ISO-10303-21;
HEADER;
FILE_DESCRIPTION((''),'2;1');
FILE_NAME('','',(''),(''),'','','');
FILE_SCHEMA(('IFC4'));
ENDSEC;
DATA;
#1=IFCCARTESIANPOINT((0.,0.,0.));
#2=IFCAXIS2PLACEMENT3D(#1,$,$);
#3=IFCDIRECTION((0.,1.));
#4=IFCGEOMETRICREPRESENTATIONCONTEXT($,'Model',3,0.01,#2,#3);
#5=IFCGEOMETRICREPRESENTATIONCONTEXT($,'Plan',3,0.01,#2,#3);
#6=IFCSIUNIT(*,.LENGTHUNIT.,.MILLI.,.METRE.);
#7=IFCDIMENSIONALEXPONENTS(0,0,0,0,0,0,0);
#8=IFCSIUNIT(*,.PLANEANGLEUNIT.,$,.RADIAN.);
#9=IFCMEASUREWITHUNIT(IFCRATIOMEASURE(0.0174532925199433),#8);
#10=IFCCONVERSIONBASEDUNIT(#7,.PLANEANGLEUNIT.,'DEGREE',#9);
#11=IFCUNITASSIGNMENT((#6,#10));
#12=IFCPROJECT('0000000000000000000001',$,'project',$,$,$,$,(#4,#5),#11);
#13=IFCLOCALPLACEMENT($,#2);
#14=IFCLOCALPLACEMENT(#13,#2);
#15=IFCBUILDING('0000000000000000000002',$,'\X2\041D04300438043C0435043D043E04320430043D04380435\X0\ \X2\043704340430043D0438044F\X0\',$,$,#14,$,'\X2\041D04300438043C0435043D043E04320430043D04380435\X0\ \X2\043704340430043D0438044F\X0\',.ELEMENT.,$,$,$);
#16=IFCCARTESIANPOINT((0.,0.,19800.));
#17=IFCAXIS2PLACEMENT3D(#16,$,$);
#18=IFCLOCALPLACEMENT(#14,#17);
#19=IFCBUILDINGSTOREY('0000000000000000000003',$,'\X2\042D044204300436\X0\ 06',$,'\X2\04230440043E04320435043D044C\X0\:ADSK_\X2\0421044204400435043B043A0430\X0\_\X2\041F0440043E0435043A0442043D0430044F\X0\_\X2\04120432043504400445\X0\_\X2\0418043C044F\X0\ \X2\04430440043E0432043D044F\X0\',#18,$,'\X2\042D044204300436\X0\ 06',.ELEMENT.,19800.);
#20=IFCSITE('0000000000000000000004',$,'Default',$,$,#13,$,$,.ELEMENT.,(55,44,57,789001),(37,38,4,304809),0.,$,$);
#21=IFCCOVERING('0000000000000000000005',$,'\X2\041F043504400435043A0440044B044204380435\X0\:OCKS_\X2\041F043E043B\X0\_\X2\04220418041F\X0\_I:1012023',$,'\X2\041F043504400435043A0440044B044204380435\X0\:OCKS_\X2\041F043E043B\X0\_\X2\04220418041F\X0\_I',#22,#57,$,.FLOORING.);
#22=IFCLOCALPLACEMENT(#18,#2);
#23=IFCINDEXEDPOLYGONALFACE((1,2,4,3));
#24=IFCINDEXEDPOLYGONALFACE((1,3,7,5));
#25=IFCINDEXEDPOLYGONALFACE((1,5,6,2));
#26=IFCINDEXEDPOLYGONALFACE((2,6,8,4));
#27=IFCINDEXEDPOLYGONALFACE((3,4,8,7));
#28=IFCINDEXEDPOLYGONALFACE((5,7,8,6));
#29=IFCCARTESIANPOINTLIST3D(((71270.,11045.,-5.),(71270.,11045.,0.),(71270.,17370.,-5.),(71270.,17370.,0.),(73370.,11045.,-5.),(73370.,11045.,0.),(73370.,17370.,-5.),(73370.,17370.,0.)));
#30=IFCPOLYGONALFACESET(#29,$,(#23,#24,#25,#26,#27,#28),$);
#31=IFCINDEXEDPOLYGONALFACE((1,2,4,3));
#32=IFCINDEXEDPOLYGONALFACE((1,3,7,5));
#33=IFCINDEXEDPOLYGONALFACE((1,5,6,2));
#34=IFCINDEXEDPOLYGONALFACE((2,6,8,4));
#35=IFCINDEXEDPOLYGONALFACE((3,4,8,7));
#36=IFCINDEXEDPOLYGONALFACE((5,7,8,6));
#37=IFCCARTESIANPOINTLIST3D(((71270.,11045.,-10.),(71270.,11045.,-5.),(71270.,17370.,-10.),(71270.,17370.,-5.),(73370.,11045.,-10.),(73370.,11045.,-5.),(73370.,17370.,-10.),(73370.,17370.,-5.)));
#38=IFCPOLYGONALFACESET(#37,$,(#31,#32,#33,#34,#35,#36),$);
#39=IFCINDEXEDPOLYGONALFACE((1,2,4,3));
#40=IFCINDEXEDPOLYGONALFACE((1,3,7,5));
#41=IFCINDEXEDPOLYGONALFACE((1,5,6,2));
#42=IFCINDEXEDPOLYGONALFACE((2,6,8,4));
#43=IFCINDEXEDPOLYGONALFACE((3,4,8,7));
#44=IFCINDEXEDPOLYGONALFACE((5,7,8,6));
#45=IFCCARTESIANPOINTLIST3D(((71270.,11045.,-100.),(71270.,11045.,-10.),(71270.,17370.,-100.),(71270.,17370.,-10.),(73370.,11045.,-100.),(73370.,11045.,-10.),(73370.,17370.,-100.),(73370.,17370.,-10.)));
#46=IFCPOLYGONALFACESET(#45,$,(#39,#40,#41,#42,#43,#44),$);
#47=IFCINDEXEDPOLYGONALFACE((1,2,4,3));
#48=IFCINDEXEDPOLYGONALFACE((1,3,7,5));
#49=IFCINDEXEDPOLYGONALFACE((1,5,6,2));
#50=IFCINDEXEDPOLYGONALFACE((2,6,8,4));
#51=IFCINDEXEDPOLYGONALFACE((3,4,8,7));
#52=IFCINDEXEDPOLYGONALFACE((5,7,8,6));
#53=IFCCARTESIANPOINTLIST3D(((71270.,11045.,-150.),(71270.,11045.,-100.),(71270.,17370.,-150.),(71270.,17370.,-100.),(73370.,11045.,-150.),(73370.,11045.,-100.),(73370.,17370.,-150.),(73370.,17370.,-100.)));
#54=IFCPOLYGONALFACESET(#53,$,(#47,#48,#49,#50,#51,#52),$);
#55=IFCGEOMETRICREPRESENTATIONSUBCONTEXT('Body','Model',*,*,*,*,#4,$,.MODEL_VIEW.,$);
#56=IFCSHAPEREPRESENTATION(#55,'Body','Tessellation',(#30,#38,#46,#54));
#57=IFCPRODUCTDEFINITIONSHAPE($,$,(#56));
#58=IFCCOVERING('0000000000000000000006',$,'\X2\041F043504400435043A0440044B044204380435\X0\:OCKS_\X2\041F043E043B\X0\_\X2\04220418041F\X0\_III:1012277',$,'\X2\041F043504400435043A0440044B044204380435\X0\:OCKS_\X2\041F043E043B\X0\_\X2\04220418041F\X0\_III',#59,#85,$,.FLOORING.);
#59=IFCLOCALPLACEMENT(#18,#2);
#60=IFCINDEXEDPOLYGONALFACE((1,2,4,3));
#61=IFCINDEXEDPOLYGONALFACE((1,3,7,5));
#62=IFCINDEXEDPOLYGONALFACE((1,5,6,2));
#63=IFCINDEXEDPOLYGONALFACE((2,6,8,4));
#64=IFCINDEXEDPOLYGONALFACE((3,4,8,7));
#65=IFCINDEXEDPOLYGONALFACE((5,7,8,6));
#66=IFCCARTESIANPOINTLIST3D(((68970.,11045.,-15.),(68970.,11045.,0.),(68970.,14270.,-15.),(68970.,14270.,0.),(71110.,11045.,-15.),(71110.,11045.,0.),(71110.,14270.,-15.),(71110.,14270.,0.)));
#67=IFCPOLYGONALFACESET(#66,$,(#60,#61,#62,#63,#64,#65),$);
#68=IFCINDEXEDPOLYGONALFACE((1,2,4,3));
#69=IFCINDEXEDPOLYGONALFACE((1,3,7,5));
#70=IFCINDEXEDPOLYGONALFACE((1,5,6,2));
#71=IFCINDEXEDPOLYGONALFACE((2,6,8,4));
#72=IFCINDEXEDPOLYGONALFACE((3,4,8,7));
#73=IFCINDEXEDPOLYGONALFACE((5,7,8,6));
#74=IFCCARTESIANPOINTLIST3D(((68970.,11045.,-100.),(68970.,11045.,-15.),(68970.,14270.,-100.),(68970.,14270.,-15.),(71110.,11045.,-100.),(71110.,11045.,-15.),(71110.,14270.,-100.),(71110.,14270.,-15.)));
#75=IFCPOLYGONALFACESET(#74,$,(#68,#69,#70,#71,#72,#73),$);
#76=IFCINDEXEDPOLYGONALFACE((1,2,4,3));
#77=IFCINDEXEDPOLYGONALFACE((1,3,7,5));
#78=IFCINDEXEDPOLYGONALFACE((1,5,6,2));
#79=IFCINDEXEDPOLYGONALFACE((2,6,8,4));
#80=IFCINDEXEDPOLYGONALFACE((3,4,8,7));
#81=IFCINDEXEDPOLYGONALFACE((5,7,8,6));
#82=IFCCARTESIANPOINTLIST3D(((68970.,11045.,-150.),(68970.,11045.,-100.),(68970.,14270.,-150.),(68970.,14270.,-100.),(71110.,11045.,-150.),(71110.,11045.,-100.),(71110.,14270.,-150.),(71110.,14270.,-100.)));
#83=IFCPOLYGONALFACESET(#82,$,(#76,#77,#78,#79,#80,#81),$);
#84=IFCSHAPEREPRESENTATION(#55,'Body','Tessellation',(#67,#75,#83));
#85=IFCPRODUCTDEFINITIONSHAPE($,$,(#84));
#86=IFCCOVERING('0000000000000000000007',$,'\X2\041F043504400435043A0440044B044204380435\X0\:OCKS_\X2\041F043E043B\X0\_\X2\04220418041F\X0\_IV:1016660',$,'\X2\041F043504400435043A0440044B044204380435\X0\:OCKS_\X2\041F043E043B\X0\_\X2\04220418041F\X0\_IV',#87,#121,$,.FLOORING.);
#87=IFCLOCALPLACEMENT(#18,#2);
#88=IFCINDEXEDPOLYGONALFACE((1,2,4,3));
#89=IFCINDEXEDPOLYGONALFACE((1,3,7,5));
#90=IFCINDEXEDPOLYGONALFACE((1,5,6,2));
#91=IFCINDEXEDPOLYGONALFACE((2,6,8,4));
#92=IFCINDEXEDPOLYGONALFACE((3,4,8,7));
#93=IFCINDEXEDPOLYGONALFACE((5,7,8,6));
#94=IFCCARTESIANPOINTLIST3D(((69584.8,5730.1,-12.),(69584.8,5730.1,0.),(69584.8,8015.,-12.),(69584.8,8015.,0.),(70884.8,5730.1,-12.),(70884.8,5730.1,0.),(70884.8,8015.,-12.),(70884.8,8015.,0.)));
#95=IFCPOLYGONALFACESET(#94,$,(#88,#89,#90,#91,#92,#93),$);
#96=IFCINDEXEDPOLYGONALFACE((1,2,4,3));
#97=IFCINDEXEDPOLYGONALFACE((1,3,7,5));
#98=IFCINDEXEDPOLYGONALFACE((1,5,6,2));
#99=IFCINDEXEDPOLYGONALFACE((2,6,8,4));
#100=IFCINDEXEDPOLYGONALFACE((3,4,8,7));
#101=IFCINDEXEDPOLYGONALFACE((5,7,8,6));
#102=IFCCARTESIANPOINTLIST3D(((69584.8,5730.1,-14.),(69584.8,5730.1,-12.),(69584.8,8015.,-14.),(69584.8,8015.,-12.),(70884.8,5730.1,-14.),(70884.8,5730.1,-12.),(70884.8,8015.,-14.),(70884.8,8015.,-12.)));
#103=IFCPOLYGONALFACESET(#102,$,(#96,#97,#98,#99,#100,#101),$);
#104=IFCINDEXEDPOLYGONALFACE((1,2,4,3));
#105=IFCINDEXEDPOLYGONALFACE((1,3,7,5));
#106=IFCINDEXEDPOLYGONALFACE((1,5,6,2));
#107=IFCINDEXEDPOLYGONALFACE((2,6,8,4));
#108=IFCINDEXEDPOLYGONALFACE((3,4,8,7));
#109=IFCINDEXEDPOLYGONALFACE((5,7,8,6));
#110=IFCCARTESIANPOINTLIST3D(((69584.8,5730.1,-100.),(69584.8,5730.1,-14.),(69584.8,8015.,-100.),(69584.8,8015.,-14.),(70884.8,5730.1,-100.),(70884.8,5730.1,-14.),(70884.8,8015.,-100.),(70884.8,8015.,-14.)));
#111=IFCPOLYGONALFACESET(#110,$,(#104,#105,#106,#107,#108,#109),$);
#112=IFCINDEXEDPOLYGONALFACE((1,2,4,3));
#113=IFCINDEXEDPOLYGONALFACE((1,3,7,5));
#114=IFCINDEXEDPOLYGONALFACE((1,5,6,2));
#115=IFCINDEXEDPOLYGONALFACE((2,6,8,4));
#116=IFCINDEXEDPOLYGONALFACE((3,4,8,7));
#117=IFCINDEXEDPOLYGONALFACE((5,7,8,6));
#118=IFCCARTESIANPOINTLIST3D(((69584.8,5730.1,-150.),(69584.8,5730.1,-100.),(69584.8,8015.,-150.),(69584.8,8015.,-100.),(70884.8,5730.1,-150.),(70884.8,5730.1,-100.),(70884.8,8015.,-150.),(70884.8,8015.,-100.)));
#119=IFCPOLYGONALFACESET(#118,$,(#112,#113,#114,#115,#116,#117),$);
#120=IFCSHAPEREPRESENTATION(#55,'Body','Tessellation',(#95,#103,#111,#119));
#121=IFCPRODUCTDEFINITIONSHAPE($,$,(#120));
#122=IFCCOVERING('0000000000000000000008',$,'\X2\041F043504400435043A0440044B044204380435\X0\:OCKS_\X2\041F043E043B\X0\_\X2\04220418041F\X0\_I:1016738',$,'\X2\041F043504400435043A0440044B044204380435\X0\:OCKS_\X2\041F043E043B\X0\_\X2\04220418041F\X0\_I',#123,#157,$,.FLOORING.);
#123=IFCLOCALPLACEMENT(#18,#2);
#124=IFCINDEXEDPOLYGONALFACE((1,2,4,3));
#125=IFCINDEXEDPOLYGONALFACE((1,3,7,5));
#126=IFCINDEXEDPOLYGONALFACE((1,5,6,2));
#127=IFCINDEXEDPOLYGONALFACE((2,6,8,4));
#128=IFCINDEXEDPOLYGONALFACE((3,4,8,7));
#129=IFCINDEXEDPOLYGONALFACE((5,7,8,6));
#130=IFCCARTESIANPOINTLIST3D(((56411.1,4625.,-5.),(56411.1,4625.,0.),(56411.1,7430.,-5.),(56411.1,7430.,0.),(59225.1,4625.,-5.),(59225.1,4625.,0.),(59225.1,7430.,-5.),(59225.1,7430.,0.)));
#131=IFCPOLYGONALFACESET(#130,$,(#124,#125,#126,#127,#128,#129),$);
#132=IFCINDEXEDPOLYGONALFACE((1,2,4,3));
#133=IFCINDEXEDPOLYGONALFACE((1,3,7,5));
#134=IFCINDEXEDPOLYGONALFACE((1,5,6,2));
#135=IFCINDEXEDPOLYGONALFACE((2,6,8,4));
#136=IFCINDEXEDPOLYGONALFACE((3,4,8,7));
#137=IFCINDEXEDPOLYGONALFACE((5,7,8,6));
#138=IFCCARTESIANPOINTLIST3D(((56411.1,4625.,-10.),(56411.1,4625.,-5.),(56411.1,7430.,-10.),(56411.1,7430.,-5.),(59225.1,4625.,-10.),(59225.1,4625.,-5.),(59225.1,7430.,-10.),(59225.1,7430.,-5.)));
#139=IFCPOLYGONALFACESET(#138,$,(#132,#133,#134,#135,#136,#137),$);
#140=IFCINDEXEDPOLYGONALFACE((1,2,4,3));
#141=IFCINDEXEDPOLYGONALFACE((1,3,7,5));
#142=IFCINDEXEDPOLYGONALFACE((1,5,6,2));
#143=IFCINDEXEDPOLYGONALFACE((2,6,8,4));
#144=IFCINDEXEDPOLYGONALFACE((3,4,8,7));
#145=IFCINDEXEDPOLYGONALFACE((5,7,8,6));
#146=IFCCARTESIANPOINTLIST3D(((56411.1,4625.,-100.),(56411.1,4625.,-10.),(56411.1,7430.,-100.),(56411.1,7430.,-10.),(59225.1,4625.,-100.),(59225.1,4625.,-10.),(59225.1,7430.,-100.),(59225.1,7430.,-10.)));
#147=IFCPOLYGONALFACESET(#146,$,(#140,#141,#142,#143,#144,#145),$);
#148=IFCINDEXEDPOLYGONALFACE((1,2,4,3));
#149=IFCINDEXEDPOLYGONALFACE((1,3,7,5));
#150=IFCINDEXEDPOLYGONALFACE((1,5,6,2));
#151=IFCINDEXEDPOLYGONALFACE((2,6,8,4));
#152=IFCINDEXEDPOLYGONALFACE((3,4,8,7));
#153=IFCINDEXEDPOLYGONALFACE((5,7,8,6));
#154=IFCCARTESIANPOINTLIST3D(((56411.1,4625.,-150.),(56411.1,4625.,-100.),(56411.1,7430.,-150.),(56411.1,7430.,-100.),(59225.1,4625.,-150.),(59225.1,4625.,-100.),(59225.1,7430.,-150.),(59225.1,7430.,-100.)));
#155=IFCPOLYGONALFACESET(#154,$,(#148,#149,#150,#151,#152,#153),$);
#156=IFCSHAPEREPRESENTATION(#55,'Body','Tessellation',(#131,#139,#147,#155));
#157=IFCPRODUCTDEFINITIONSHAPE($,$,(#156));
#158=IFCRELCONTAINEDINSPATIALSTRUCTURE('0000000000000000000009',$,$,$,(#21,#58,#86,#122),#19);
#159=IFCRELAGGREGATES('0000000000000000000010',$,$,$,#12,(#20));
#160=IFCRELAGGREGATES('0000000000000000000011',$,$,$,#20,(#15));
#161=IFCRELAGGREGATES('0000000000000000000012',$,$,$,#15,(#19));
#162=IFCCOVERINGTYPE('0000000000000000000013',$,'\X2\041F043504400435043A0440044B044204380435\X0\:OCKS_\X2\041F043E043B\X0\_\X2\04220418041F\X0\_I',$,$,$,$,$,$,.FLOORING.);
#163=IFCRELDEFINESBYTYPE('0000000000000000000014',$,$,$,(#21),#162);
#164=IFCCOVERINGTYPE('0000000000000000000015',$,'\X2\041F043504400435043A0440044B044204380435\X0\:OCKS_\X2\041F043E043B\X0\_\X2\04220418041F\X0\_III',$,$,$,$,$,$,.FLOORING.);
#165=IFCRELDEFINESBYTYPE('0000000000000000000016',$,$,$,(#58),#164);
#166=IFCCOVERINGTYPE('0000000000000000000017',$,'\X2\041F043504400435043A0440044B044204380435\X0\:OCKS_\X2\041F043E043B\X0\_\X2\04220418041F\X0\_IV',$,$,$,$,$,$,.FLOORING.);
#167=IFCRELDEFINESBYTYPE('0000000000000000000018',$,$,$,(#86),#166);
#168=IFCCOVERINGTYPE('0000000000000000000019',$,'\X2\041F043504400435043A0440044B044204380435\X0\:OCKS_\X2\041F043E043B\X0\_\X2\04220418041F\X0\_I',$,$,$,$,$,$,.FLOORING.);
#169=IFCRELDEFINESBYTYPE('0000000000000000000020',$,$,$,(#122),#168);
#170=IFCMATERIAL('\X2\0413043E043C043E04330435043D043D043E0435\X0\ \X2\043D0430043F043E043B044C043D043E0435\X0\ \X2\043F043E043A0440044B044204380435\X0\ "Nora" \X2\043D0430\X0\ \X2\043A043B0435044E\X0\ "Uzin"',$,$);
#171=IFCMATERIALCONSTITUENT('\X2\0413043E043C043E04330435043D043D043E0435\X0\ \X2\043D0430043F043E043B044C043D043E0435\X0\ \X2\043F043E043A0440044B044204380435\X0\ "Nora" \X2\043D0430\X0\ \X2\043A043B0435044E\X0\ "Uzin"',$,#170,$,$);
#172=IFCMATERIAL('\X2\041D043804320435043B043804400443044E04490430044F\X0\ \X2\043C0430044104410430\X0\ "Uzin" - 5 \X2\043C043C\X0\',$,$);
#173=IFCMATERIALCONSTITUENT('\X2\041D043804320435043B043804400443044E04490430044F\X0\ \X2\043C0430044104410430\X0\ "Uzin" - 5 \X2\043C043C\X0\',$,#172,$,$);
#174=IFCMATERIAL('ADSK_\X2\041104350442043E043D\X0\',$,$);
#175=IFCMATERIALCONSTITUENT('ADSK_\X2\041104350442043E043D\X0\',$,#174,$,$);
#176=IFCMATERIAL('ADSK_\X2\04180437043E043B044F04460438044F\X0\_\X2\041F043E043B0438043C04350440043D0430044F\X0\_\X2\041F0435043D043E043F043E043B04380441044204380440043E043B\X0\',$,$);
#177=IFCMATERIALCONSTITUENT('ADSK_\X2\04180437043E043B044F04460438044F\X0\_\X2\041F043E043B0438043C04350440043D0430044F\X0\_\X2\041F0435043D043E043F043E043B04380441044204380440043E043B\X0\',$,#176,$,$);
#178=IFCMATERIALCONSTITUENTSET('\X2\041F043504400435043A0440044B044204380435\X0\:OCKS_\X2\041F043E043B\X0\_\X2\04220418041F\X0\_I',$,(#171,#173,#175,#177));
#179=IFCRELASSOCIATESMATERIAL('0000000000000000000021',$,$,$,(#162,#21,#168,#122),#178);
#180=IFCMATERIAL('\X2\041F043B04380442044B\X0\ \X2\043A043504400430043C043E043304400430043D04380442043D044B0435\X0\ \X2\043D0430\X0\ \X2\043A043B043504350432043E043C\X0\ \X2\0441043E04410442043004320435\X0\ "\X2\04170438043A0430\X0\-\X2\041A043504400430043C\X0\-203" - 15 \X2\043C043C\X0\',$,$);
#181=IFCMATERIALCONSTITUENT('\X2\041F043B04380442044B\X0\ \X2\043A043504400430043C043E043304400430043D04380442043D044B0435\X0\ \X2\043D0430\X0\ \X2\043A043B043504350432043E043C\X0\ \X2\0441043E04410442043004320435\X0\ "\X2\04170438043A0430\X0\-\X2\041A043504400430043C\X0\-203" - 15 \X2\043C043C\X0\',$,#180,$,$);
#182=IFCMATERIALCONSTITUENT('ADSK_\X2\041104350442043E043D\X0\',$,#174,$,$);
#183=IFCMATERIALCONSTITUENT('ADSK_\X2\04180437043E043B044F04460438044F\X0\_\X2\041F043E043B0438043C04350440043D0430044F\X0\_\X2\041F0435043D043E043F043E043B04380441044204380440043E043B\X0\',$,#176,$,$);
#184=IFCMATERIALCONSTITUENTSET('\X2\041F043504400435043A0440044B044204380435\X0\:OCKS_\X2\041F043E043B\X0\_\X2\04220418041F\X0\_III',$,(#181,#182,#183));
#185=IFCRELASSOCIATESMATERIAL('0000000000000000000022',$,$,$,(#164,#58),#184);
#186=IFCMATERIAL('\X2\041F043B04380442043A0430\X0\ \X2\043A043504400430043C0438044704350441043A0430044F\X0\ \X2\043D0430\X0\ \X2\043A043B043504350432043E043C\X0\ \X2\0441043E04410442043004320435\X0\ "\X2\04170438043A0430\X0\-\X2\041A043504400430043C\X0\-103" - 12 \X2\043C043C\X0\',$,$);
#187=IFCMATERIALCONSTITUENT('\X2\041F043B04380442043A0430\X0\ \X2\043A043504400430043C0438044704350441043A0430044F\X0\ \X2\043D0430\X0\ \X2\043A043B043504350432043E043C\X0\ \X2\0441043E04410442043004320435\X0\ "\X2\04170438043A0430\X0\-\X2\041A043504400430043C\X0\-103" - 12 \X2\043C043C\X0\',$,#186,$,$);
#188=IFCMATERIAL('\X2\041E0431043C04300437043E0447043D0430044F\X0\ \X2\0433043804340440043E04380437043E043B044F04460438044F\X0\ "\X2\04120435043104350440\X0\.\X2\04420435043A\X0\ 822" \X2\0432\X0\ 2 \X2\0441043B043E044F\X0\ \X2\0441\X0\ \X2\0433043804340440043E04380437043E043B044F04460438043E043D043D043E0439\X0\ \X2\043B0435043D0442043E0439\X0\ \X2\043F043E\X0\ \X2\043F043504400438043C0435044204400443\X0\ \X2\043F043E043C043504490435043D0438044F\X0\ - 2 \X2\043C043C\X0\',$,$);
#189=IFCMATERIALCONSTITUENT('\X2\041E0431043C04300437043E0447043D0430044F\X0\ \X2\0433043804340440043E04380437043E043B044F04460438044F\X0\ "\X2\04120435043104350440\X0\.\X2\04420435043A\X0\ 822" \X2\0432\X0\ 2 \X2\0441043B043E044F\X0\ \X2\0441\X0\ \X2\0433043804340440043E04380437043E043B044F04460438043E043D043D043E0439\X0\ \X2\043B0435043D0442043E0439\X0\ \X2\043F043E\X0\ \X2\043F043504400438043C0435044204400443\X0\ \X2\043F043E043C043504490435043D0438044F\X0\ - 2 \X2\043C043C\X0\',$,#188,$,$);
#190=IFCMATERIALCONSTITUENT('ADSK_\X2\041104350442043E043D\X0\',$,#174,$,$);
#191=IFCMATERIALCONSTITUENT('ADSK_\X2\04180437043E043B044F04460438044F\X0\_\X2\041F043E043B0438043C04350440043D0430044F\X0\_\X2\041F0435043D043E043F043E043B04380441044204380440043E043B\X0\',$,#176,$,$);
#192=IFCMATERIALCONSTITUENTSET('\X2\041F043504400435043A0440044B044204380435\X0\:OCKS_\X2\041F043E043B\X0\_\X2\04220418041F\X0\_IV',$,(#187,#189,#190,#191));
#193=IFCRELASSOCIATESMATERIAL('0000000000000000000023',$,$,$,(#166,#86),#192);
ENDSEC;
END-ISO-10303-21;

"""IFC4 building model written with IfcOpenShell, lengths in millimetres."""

from ifc_helpers import new_model, entity, si_unit, converted_unit, direction, frame, origin, place, context, subcontext, project, spatial, indexed_curve, outline, extrude, material, constituent, constituent_set, type_object, element, save


model = new_model("IFC4")

# Units and contexts
model_context = context("Model", 3, precision=0.01, world=origin(), true_north=direction((0.0, 1.0)))
plan_context = context("Plan", 3, precision=0.01, world=origin(), true_north=direction((0.0, 1.0)))
body_context = subcontext(model_context, "Body", "Model", "MODEL_VIEW")
ifc_project = project(units=[si_unit("LENGTHUNIT", "METRE", prefix="MILLI"), converted_unit("PLANEANGLEUNIT", "DEGREE", entity("IfcRatioMeasure", 0.0174532925199433), si_unit("PLANEANGLEUNIT", "RADIAN"), dimensions=[0, 0, 0, 0, 0, 0, 0])], contexts=[model_context, plan_context])

# Site, building, storey
site_placement = place(None, frame((0.0, 0.0, 0.0)))
site = spatial("IfcSite", under=ifc_project, at=site_placement, Name="Default", CompositionType="ELEMENT", RefLatitude=(55, 44, 57, 789001), RefLongitude=(37, 38, 4, 304809), RefElevation=0.0)
building_placement = place(site_placement, origin())
building = spatial("IfcBuilding", under=site, at=building_placement, Name="Наименование здания", LongName="Наименование здания", CompositionType="ELEMENT")
storey_placement = place(building_placement, frame((0.0, 0.0, 19800.0)))
storey = spatial("IfcBuildingStorey", under=building, at=storey_placement, Name="Этаж 06", ObjectType="Уровень:ADSK_Стрелка_Проектная_Вверх_Имя уровня", LongName="Этаж 06", CompositionType="ELEMENT", Elevation=19800.0)

# Coverings
ifc_material_1 = material(Name="Плиты керамогранитные на клеевом составе \"Зика-Керам-203\" - 15 мм")
ifc_material_2 = material(Name="Обмазочная гидроизоляция \"Вебер.тек 822\" в 2 слоя с гидроизоляционной лентой по периметру помещения - 2 мм")
ifc_material_3 = material(Name="ADSK_Бетон")
ifc_material_4 = material(Name="ADSK_Изоляция_Полимерная_Пенополистирол")
ifc_material_5 = material(Name="Гомогенное напольное покрытие \"Nora\" на клею \"Uzin\"")
ifc_constituent_1 = constituent(ifc_material_5, Name="Гомогенное напольное покрытие \"Nora\" на клею \"Uzin\"")
ifc_material_6 = material(Name="Нивелирующая масса \"Uzin\" - 5 мм")
ifc_constituent_2 = constituent(ifc_material_6, Name="Нивелирующая масса \"Uzin\" - 5 мм")
ifc_constituent_3 = constituent(ifc_material_3, Name="ADSK_Бетон")
ifc_constituent_4 = constituent(ifc_material_4, Name="ADSK_Изоляция_Полимерная_Пенополистирол")
ifc_constituent_set_1 = constituent_set(constituents=[ifc_constituent_1, ifc_constituent_2, ifc_constituent_3, ifc_constituent_4], Name="Перекрытие:OCKS_Пол_ТИП_I")
covering_type_1 = type_object("IfcCoveringType", Name="Перекрытие:OCKS_Пол_ТИП_I", PredefinedType="FLOORING", material=ifc_constituent_set_1)
covering_1_placement = place(storey_placement, origin())
element("IfcCovering", 1, at=covering_1_placement, inside=storey, type_object=covering_type_1, material=ifc_constituent_set_1, Name="Перекрытие:OCKS_Пол_ТИП_I:1012023", ObjectType="Перекрытие:OCKS_Пол_ТИП_I", PredefinedType="FLOORING", context=body_context, shape_type="SweptSolid", body=[
    extrude(outline(indexed_curve([(-1050.0, -3162.5), (1050.0, -3162.5), (1050.0, 3162.5), (-1050.0, 3162.5), (-1050.0, -3162.5)], self_intersect=False)), frame((72320.0, 14207.5, -5.0)), (0.0, 0.0, 1.0), 5.0),
    extrude(outline(indexed_curve([(-1050.0, -3162.5), (1050.0, -3162.5), (1050.0, 3162.5), (-1050.0, 3162.5), (-1050.0, -3162.5)], self_intersect=False)), frame((72320.0, 14207.5, -10.0)), (0.0, 0.0, 1.0), 5.0),
    extrude(outline(indexed_curve([(-1050.0, -3162.5), (1050.0, -3162.5), (1050.0, 3162.5), (-1050.0, 3162.5), (-1050.0, -3162.5)], self_intersect=False)), frame((72320.0, 14207.5, -100.0)), (0.0, 0.0, 1.0), 90.0),
    extrude(outline(indexed_curve([(-1050.0, -3162.5), (1050.0, -3162.5), (1050.0, 3162.5), (-1050.0, 3162.5), (-1050.0, -3162.5)], self_intersect=False)), frame((72320.0, 14207.5, -150.0)), (0.0, 0.0, 1.0), 50.0),
])
ifc_constituent_5 = constituent(ifc_material_1, Name="Плиты керамогранитные на клеевом составе \"Зика-Керам-203\" - 15 мм")
ifc_constituent_6 = constituent(ifc_material_3, Name="ADSK_Бетон")
ifc_constituent_7 = constituent(ifc_material_4, Name="ADSK_Изоляция_Полимерная_Пенополистирол")
ifc_constituent_set_2 = constituent_set(constituents=[ifc_constituent_5, ifc_constituent_6, ifc_constituent_7], Name="Перекрытие:OCKS_Пол_ТИП_III")
covering_type_2 = type_object("IfcCoveringType", Name="Перекрытие:OCKS_Пол_ТИП_III", PredefinedType="FLOORING", material=ifc_constituent_set_2)
covering_2_placement = place(storey_placement, origin())
element("IfcCovering", 2, at=covering_2_placement, inside=storey, type_object=covering_type_2, material=ifc_constituent_set_2, Name="Перекрытие:OCKS_Пол_ТИП_III:1012277", ObjectType="Перекрытие:OCKS_Пол_ТИП_III", PredefinedType="FLOORING", context=body_context, shape_type="SweptSolid", body=[
    extrude(outline(indexed_curve([(-1070.0, -1612.5), (1070.0, -1612.5), (1070.0, 1612.5), (-1070.0, 1612.5), (-1070.0, -1612.5)], self_intersect=False)), frame((70040.0, 12657.5, -15.0), z_axis=(0.0, 0.0, 1.0), x_axis=(-1.0, 0.0, 0.0)), (0.0, 0.0, 1.0), 15.0),
    extrude(outline(indexed_curve([(-1070.0, -1612.5), (1070.0, -1612.5), (1070.0, 1612.5), (-1070.0, 1612.5), (-1070.0, -1612.5)], self_intersect=False)), frame((70040.0, 12657.5, -100.0), z_axis=(0.0, 0.0, 1.0), x_axis=(-1.0, 0.0, 0.0)), (0.0, 0.0, 1.0), 85.0),
    extrude(outline(indexed_curve([(-1070.0, -1612.5), (1070.0, -1612.5), (1070.0, 1612.5), (-1070.0, 1612.5), (-1070.0, -1612.5)], self_intersect=False)), frame((70040.0, 12657.5, -150.0), z_axis=(0.0, 0.0, 1.0), x_axis=(-1.0, 0.0, 0.0)), (0.0, 0.0, 1.0), 50.0),
])
ifc_material_7 = material(Name="Плитка керамическая на клеевом составе \"Зика-Керам-103\" - 12 мм")
ifc_constituent_8 = constituent(ifc_material_7, Name="Плитка керамическая на клеевом составе \"Зика-Керам-103\" - 12 мм")
ifc_constituent_9 = constituent(ifc_material_2, Name="Обмазочная гидроизоляция \"Вебер.тек 822\" в 2 слоя с гидроизоляционной лентой по периметру помещения - 2 мм")
ifc_constituent_10 = constituent(ifc_material_3, Name="ADSK_Бетон")
ifc_constituent_11 = constituent(ifc_material_4, Name="ADSK_Изоляция_Полимерная_Пенополистирол")
ifc_constituent_set_3 = constituent_set(constituents=[ifc_constituent_8, ifc_constituent_9, ifc_constituent_10, ifc_constituent_11], Name="Перекрытие:OCKS_Пол_ТИП_IV")
covering_type_3 = type_object("IfcCoveringType", Name="Перекрытие:OCKS_Пол_ТИП_IV", PredefinedType="FLOORING", material=ifc_constituent_set_3)
covering_3_placement = place(storey_placement, origin())
element("IfcCovering", 3, at=covering_3_placement, inside=storey, type_object=covering_type_3, material=ifc_constituent_set_3, Name="Перекрытие:OCKS_Пол_ТИП_IV:1016660", ObjectType="Перекрытие:OCKS_Пол_ТИП_IV", PredefinedType="FLOORING", context=body_context, shape_type="SweptSolid", body=[
    extrude(outline(indexed_curve([(-650.0, -1142.4), (650.0, -1142.4), (650.0, 1142.4), (-650.0, 1142.4), (-650.0, -1142.4)], self_intersect=False)), frame((70234.8, 6872.6, -12.0), z_axis=(0.0, 0.0, 1.0), x_axis=(-1.0, 0.0, 0.0)), (0.0, 0.0, 1.0), 12.0),
    extrude(outline(indexed_curve([(-650.0, -1142.4), (650.0, -1142.4), (650.0, 1142.4), (-650.0, 1142.4), (-650.0, -1142.4)], self_intersect=False)), frame((70234.8, 6872.6, -14.0), z_axis=(0.0, 0.0, 1.0), x_axis=(-1.0, 0.0, 0.0)), (0.0, 0.0, 1.0), 2.0),
    extrude(outline(indexed_curve([(-650.0, -1142.4), (650.0, -1142.4), (650.0, 1142.4), (-650.0, 1142.4), (-650.0, -1142.4)], self_intersect=False)), frame((70234.8, 6872.6, -100.0), z_axis=(0.0, 0.0, 1.0), x_axis=(-1.0, 0.0, 0.0)), (0.0, 0.0, 1.0), 86.0),
    extrude(outline(indexed_curve([(-650.0, -1142.4), (650.0, -1142.4), (650.0, 1142.4), (-650.0, 1142.4), (-650.0, -1142.4)], self_intersect=False)), frame((70234.8, 6872.6, -150.0), z_axis=(0.0, 0.0, 1.0), x_axis=(-1.0, 0.0, 0.0)), (0.0, 0.0, 1.0), 50.0),
])
covering_type_4 = type_object("IfcCoveringType", Name="Перекрытие:OCKS_Пол_ТИП_I", PredefinedType="FLOORING", material=ifc_constituent_set_1)
covering_4_placement = place(storey_placement, origin())
element("IfcCovering", 4, at=covering_4_placement, inside=storey, type_object=covering_type_4, material=ifc_constituent_set_1, Name="Перекрытие:OCKS_Пол_ТИП_I:1016738", ObjectType="Перекрытие:OCKS_Пол_ТИП_I", PredefinedType="FLOORING", context=body_context, shape_type="SweptSolid", body=[
    extrude(outline(indexed_curve([(-1407.0, -1402.5), (1407.0, -1402.5), (1407.0, 1402.5), (-1407.0, 1402.5), (-1407.0, -1402.5)], self_intersect=False)), frame((57818.1, 6027.5, -5.0), z_axis=(0.0, 0.0, 1.0), x_axis=(-1.0, 0.0, 0.0)), (0.0, 0.0, 1.0), 5.0),
    extrude(outline(indexed_curve([(-1407.0, -1402.5), (1407.0, -1402.5), (1407.0, 1402.5), (-1407.0, 1402.5), (-1407.0, -1402.5)], self_intersect=False)), frame((57818.1, 6027.5, -10.0), z_axis=(0.0, 0.0, 1.0), x_axis=(-1.0, 0.0, 0.0)), (0.0, 0.0, 1.0), 5.0),
    extrude(outline(indexed_curve([(-1407.0, -1402.5), (1407.0, -1402.5), (1407.0, 1402.5), (-1407.0, 1402.5), (-1407.0, -1402.5)], self_intersect=False)), frame((57818.1, 6027.5, -100.0), z_axis=(0.0, 0.0, 1.0), x_axis=(-1.0, 0.0, 0.0)), (0.0, 0.0, 1.0), 90.0),
    extrude(outline(indexed_curve([(-1407.0, -1402.5), (1407.0, -1402.5), (1407.0, 1402.5), (-1407.0, 1402.5), (-1407.0, -1402.5)], self_intersect=False)), frame((57818.1, 6027.5, -150.0), z_axis=(0.0, 0.0, 1.0), x_axis=(-1.0, 0.0, 0.0)), (0.0, 0.0, 1.0), 50.0),
])

save(model, "model.ifc")
